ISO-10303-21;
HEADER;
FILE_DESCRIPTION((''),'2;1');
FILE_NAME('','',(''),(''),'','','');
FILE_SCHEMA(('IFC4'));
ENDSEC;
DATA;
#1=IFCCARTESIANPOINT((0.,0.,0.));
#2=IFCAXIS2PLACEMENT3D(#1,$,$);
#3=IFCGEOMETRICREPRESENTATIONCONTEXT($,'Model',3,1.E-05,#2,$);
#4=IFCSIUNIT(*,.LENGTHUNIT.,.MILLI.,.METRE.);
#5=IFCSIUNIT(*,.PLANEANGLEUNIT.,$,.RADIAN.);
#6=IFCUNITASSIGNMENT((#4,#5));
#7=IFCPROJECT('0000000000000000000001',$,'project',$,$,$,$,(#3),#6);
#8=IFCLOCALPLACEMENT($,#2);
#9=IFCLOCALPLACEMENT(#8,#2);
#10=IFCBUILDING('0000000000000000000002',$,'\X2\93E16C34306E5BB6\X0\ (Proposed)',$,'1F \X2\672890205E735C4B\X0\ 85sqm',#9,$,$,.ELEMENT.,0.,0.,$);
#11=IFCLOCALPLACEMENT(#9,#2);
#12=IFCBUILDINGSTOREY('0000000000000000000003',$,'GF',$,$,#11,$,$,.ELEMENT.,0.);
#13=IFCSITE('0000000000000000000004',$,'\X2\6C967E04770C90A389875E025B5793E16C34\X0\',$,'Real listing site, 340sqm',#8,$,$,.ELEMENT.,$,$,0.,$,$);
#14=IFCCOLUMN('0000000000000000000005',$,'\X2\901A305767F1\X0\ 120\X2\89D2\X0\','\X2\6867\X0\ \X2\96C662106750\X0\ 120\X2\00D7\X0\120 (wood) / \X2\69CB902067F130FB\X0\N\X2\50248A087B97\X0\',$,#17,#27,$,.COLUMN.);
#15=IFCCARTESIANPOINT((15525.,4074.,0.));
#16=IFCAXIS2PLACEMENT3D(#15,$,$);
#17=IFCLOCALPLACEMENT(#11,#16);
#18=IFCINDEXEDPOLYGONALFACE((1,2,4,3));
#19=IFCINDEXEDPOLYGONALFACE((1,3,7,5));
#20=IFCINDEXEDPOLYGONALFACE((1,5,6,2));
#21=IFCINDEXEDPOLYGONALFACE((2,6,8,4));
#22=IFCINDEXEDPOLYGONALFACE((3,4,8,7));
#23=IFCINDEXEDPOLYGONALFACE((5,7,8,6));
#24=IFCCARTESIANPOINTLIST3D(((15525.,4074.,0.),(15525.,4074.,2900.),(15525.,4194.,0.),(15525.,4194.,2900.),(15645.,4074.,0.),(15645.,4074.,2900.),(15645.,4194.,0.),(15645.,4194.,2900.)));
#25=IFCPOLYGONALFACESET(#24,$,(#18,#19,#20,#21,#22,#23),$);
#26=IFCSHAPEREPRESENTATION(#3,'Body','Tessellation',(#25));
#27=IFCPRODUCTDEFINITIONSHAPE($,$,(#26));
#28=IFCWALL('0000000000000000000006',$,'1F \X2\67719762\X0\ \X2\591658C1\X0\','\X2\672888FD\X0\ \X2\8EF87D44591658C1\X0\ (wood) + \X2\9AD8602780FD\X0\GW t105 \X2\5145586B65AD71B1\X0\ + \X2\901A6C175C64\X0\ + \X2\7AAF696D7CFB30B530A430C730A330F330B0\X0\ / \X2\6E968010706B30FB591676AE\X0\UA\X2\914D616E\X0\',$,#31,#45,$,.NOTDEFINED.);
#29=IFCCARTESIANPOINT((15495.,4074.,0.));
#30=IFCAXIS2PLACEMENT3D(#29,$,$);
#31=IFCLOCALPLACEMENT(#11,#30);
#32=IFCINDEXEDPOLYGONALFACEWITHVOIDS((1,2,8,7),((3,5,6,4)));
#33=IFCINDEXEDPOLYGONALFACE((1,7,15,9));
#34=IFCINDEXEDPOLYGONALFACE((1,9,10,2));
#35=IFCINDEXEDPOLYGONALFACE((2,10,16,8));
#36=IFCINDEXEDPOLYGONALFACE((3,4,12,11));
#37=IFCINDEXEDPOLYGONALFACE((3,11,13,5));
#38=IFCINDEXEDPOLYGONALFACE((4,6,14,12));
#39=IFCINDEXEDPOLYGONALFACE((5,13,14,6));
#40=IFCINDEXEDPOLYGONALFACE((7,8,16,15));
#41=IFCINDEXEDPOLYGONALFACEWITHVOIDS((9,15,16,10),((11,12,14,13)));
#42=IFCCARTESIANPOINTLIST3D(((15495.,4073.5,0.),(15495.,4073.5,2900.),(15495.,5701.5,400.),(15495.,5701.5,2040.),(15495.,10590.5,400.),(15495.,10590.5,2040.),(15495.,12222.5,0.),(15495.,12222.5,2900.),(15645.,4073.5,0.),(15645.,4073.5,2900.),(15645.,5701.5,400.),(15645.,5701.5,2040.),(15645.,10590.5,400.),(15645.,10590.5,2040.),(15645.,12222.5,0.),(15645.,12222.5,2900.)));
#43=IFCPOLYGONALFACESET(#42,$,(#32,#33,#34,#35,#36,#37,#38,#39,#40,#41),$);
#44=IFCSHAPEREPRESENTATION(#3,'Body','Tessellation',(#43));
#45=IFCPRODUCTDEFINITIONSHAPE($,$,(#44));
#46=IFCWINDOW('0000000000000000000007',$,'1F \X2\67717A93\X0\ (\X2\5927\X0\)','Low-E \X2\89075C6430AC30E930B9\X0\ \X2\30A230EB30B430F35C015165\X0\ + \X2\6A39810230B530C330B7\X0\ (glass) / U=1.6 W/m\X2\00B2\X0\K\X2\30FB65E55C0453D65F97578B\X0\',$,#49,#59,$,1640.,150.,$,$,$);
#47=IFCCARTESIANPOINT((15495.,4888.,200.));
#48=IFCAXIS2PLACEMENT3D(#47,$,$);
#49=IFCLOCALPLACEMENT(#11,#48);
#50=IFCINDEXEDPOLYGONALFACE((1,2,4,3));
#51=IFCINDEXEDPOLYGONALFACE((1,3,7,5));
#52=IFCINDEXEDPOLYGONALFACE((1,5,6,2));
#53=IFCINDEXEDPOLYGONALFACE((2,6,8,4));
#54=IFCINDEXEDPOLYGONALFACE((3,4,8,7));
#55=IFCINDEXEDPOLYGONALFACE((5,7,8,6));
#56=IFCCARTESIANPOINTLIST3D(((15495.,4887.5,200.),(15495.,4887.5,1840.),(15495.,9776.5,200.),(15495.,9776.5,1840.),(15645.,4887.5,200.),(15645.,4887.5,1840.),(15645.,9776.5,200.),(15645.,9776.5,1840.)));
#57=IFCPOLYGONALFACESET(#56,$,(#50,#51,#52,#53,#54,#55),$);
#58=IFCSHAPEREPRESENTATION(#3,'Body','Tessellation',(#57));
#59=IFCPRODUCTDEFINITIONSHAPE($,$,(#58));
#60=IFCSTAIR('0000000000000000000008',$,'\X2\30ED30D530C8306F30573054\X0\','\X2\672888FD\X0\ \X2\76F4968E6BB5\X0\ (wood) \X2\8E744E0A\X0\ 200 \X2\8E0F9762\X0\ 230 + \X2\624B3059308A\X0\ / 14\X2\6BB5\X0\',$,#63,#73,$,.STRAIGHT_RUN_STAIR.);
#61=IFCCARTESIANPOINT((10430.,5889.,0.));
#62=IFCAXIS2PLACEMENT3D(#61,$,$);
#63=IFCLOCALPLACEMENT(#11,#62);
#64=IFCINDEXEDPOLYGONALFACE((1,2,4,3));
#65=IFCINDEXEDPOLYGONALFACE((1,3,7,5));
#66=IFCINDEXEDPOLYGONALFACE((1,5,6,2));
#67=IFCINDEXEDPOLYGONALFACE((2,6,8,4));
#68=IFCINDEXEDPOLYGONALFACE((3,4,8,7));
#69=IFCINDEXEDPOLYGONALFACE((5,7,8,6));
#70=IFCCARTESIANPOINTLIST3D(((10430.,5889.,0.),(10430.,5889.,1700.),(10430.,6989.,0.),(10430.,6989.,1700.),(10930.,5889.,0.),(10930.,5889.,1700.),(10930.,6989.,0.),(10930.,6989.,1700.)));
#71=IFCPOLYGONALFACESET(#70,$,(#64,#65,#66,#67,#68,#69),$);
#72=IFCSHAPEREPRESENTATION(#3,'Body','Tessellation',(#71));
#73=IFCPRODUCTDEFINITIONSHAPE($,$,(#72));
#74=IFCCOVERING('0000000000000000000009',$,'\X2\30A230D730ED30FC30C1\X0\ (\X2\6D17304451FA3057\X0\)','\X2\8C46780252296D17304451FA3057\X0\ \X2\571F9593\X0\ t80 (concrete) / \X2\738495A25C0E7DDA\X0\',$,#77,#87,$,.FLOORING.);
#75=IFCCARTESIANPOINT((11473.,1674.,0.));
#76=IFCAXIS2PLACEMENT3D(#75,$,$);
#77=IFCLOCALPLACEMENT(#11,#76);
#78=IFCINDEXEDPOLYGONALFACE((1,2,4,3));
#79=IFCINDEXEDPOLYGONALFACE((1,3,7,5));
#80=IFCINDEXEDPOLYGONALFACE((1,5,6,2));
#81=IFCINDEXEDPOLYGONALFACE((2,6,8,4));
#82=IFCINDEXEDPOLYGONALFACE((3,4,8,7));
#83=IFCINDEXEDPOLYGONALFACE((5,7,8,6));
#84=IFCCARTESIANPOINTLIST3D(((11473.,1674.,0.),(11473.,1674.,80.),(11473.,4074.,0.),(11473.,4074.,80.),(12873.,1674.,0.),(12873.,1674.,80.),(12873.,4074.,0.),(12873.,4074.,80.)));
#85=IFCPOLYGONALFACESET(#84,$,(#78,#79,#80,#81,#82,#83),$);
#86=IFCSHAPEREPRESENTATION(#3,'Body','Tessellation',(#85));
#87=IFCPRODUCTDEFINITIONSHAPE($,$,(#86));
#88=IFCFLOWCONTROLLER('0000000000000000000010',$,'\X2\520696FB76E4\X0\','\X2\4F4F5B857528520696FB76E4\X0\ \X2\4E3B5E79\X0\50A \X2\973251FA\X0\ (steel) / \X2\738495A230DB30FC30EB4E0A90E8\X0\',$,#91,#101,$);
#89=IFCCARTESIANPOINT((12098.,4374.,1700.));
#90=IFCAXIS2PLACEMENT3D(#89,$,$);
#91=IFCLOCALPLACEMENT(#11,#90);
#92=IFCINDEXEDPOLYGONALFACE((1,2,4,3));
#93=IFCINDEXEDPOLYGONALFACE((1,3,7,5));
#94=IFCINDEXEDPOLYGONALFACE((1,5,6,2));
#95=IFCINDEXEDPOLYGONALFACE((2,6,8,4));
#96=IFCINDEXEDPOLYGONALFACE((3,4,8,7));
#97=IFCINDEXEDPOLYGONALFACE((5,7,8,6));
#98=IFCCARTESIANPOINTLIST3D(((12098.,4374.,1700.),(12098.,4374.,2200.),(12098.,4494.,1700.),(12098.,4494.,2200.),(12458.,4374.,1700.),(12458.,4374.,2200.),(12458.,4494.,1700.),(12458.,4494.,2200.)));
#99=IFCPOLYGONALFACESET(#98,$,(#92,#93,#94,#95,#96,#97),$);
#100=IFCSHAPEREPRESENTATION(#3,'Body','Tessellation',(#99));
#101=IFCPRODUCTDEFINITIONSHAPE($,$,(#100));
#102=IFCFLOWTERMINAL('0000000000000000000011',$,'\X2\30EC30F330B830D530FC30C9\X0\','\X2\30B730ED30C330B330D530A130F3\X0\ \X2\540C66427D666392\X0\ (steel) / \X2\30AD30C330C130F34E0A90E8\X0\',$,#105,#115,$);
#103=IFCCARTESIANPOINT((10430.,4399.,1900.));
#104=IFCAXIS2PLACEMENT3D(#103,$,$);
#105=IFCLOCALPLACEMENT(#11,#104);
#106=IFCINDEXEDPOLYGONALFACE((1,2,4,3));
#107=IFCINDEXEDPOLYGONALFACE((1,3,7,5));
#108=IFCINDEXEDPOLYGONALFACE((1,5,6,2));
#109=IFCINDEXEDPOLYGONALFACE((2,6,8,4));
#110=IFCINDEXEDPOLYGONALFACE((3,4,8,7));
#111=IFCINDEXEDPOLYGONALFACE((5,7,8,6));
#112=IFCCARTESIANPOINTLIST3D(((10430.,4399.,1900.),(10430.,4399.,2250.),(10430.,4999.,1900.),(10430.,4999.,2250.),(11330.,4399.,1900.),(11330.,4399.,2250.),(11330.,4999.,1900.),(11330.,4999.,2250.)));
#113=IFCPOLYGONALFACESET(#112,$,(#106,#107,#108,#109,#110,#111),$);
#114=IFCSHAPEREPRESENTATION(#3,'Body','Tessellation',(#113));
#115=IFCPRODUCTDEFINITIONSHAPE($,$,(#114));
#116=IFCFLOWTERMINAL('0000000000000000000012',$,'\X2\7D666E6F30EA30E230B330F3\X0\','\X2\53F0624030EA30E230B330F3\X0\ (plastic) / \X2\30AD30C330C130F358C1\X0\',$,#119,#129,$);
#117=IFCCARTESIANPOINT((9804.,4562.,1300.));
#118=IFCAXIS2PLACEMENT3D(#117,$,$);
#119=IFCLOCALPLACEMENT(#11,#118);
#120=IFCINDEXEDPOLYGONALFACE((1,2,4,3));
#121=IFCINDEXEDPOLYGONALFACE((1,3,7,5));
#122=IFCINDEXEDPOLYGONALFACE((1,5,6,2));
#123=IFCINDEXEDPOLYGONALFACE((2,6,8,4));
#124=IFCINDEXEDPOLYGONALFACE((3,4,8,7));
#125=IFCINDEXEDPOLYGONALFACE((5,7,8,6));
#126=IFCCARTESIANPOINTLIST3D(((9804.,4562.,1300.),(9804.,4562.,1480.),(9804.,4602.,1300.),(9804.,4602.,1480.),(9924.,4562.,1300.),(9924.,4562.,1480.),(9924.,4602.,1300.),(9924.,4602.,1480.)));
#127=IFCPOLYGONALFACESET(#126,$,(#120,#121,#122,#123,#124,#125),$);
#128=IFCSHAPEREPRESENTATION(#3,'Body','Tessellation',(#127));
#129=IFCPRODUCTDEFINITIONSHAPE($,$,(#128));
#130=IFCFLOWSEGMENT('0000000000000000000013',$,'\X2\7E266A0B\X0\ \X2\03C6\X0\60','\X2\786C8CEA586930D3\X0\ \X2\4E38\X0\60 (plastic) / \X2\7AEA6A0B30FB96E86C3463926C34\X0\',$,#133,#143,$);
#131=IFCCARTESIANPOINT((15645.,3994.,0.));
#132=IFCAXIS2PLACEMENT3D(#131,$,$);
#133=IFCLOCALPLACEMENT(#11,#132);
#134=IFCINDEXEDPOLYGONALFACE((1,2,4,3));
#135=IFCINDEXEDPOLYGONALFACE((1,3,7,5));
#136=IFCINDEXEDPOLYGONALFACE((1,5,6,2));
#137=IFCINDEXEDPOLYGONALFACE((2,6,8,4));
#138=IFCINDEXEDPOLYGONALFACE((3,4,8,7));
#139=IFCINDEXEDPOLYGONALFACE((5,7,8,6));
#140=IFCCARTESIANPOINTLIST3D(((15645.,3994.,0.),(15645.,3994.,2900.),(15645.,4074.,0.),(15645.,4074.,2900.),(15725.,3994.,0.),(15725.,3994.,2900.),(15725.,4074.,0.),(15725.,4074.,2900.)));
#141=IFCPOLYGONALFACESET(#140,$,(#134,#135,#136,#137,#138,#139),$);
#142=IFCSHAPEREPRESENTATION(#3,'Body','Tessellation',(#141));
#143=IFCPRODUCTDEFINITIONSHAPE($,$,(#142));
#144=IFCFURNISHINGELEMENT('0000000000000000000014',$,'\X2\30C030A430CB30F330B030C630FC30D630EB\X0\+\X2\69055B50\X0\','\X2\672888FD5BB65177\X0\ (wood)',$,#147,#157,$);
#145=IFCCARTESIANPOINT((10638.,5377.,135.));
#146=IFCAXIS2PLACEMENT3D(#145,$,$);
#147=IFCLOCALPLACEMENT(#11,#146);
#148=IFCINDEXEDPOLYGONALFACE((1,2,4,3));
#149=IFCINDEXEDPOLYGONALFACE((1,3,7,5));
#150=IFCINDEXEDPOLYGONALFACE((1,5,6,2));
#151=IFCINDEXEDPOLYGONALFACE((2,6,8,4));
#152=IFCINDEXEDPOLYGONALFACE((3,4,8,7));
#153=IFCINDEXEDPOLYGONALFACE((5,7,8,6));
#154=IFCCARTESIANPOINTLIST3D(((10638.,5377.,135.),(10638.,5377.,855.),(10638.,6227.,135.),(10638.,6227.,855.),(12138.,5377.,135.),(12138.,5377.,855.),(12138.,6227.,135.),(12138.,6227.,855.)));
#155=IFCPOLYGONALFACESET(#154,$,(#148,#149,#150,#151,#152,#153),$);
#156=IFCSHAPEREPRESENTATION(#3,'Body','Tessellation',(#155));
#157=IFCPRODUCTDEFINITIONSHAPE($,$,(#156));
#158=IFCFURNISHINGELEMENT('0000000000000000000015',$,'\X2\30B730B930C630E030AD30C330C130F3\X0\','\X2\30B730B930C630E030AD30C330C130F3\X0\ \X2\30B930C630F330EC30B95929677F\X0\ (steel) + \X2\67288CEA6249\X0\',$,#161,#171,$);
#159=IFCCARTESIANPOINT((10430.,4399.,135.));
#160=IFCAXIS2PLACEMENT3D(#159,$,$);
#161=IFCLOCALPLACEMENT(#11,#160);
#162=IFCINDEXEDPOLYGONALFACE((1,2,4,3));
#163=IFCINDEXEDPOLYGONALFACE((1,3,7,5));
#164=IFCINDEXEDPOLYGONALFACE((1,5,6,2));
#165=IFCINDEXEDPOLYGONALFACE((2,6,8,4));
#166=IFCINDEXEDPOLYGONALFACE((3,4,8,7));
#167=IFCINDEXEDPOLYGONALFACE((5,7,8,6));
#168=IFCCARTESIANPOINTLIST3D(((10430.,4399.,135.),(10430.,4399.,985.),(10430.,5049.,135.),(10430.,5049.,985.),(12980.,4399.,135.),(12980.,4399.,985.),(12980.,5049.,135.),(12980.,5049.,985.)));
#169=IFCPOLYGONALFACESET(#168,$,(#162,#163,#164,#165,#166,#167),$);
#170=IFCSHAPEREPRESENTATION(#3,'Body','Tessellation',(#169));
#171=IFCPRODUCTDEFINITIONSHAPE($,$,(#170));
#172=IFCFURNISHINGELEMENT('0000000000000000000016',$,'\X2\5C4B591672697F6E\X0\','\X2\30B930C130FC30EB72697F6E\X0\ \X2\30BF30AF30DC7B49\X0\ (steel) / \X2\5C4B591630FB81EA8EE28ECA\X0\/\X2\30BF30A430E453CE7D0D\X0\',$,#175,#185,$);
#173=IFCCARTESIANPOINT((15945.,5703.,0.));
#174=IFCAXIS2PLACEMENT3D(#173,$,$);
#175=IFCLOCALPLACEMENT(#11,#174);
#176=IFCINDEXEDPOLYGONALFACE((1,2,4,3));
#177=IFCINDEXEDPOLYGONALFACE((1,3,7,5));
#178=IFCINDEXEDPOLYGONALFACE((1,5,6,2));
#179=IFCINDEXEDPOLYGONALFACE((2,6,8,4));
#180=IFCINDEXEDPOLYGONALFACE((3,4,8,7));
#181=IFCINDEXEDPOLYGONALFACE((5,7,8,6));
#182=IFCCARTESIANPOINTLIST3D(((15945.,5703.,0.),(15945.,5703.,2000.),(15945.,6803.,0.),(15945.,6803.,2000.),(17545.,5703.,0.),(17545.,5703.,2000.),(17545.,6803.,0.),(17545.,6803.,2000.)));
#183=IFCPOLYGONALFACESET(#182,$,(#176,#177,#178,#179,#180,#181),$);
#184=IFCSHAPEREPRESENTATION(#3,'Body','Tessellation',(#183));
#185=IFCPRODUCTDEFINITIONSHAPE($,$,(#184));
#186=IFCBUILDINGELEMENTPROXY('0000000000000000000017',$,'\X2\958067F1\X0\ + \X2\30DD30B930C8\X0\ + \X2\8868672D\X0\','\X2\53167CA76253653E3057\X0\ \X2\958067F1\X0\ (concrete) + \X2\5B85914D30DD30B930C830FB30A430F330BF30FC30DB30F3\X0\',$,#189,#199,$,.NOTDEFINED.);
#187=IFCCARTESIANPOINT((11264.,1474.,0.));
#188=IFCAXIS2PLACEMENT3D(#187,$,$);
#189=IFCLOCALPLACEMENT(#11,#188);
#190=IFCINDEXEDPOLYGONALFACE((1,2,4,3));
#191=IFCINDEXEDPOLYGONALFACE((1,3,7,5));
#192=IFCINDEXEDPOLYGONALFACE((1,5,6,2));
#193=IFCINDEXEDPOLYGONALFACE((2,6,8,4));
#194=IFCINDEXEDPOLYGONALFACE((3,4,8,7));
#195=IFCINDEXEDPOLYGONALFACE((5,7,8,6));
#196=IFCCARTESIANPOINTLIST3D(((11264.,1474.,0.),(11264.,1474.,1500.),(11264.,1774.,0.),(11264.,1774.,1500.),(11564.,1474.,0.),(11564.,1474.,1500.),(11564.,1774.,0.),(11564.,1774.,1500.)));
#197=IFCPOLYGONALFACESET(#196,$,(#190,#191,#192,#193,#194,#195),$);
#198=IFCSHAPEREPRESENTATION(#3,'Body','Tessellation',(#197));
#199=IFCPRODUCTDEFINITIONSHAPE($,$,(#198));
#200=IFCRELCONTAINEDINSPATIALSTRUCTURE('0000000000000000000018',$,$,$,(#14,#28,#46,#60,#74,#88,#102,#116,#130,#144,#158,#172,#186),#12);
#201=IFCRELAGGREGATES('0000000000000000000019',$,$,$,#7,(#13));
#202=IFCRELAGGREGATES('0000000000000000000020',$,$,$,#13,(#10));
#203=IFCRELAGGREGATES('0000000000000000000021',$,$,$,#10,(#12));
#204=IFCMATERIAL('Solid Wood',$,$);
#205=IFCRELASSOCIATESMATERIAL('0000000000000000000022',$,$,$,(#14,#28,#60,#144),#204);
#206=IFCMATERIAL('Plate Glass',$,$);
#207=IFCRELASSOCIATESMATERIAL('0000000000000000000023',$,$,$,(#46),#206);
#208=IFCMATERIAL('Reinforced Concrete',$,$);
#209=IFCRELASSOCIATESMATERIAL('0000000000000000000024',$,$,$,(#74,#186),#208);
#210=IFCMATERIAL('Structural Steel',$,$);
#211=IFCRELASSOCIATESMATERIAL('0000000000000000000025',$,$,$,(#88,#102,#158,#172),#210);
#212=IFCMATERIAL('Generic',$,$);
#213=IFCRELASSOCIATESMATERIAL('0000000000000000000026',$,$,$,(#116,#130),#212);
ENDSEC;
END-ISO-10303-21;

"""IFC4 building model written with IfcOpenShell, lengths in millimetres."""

from ifc_helpers import new_model, si_unit, frame, frame_2d, origin, place, context, project, spatial, rectangle, extrude, material, element, fill, save


model = new_model("IFC4")

# Units and contexts
model_context = context("Model", 3, precision=1e-05, world=origin())
ifc_project = project(units=[si_unit("LENGTHUNIT", "METRE", prefix="MILLI"), si_unit("PLANEANGLEUNIT", "RADIAN")], contexts=[model_context])

# Site, building, storey
site_placement = place(None, origin())
site = spatial("IfcSite", under=ifc_project, at=site_placement, Name="沖縄県那覇市字鏡水", ObjectType="Real listing site, 340sqm", CompositionType="ELEMENT", RefElevation=0.0)
building_placement = place(site_placement, origin())
building = spatial("IfcBuilding", under=site, at=building_placement, Name="鏡水の家 (Proposed)", ObjectType="1F 木造平屋 85sqm", CompositionType="ELEMENT", ElevationOfRefHeight=0.0, ElevationOfTerrain=0.0)
storey_placement = place(building_placement, origin())
storey = spatial("IfcBuildingStorey", under=building, at=storey_placement, Name="GF", CompositionType="ELEMENT", Elevation=0.0)

# Column
ifc_material_1 = material(Name="Solid Wood")
column_1_placement = place(storey_placement, frame((15525.0, 4074.0, 0.0)))
element("IfcColumn", 1, at=column_1_placement, inside=storey, material=ifc_material_1, Name="通し柱 120角", Description="桧 集成材 120×120 (wood) / 構造柱・N値計算", PredefinedType="COLUMN", context=model_context, shape_type="SweptSolid", body=[
    extrude(rectangle(XDim=120.0, YDim=120.0, at=frame_2d((60.0, 60.0))), frame((15525.0, 4074.0, 0.0)), (0.0, 0.0, 1.0), 2900.0),
])

# Wall, opening, window
wall_1_placement = place(storey_placement, frame((15495.0, 4074.0, 0.0)))
wall_1 = element("IfcWall", 2, at=wall_1_placement, inside=storey, material=ifc_material_1, Name="1F 東面 外壁", Description="木製 軸組外壁 (wood) + 高性能GW t105 充填断熱 + 通気層 + 窯業系サイディング / 準耐火・外皮UA配慮", PredefinedType="NOTDEFINED", context=model_context, shape_type="SweptSolid", body=[
    extrude(rectangle(XDim=150.0, YDim=8149.0, at=frame_2d((75.0, 4074.0))), frame((15495.0, 4074.0, 0.0)), (0.0, 0.0, 1.0), 2900.0),
])
opening_placement = place(storey_placement, frame((15495.0, 4888.0, 200.0)))
opening = element("IfcOpeningElement", 3, at=opening_placement, cuts=wall_1, PredefinedType="NOTDEFINED", context=model_context, shape_type="SweptSolid", body=[
    extrude(rectangle(XDim=150.0, YDim=4889.0, at=frame_2d((75.0, 2444.0))), frame((15495.0, 4888.0, 200.0)), (0.0, 0.0, 1.0), 1640.0),
])
ifc_material_2 = material(Name="Plate Glass")
window_placement = place(storey_placement, frame((15495.0, 4888.0, 200.0)))
window = element("IfcWindow", 4, at=window_placement, inside=storey, material=ifc_material_2, Name="1F 東窓 (大)", Description="Low-E 複層ガラス アルゴン封入 + 樹脂サッシ (glass) / U=1.6 W/m²K・日射取得型", OverallHeight=1640.0, OverallWidth=150.0, context=model_context, shape_type="SweptSolid", body=[
    extrude(rectangle(XDim=150.0, YDim=4889.0, at=frame_2d((75.0, 2444.0))), frame((15495.0, 4888.0, 200.0)), (0.0, 0.0, 1.0), 1640.0),
])
fill(opening, window)

# Stair
stair_placement = place(storey_placement, frame((10430.0, 5889.0, 0.0)))
element("IfcStair", 5, at=stair_placement, inside=storey, material=ifc_material_1, Name="ロフトはしご", Description="木製 直階段 (wood) 蹴上 200 踏面 230 + 手すり / 14段", PredefinedType="STRAIGHT_RUN_STAIR", context=model_context, shape_type="SweptSolid", body=[
    extrude(rectangle(XDim=500.0, YDim=1100.0, at=frame_2d((250.0, 550.0))), frame((10430.0, 5889.0, 0.0)), (0.0, 0.0, 1.0), 1700.0),
])

# Covering
ifc_material_3 = material(Name="Reinforced Concrete")
covering_placement = place(storey_placement, frame((11473.0, 1674.0, 0.0)))
element("IfcCovering", 6, at=covering_placement, inside=storey, material=ifc_material_3, Name="アプローチ (洗い出し)", Description="豆砂利洗い出し 土間 t80 (concrete) / 玄関導線", PredefinedType="FLOORING", context=model_context, shape_type="SweptSolid", body=[
    extrude(rectangle(XDim=1400.0, YDim=2400.0, at=frame_2d((700.0, 1200.0))), frame((11473.0, 1674.0, 0.0)), (0.0, 0.0, 1.0), 80.0),
])

# Flow controller
ifc_material_4 = material(Name="Structural Steel")
flow_controller_placement = place(storey_placement, frame((12098.0, 4374.0, 1700.0)))
element("IfcFlowController", 7, at=flow_controller_placement, inside=storey, material=ifc_material_4, Name="分電盤", Description="住宅用分電盤 主幹50A 露出 (steel) / 玄関ホール上部", context=model_context, shape_type="SweptSolid", body=[
    extrude(rectangle(XDim=360.0, YDim=120.0, at=frame_2d((180.0, 60.0))), frame((12098.0, 4374.0, 1700.0)), (0.0, 0.0, 1.0), 500.0),
])

# Flow terminals
flow_terminal_1_placement = place(storey_placement, frame((10430.0, 4399.0, 1900.0)))
element("IfcFlowTerminal", 8, at=flow_terminal_1_placement, inside=storey, material=ifc_material_4, Name="レンジフード", Description="シロッコファン 同時給排 (steel) / キッチン上部", context=model_context, shape_type="SweptSolid", body=[
    extrude(rectangle(XDim=900.0, YDim=600.0, at=frame_2d((450.0, 300.0))), frame((10430.0, 4399.0, 1900.0)), (0.0, 0.0, 1.0), 350.0),
])
ifc_material_5 = material(Name="Generic")
flow_terminal_2_placement = place(storey_placement, frame((9804.0, 4562.0, 1300.0)))
element("IfcFlowTerminal", 9, at=flow_terminal_2_placement, inside=storey, material=ifc_material_5, Name="給湯リモコン", Description="台所リモコン (plastic) / キッチン壁", context=model_context, shape_type="SweptSolid", body=[
    extrude(rectangle(XDim=120.0, YDim=40.0, at=frame_2d((60.0, 20.0))), frame((9804.0, 4562.0, 1300.0)), (0.0, 0.0, 1.0), 180.0),
])

# Flow segment
flow_segment_placement = place(storey_placement, frame((15645.0, 3994.0, 0.0)))
element("IfcFlowSegment", 10, at=flow_segment_placement, inside=storey, material=ifc_material_5, Name="縦樋 φ60", Description="硬質塩ビ 丸60 (plastic) / 竪樋・雨水排水", context=model_context, shape_type="SweptSolid", body=[
    extrude(rectangle(XDim=80.0, YDim=80.0, at=frame_2d((40.0, 40.0))), frame((15645.0, 3994.0, 0.0)), (0.0, 0.0, 1.0), 2900.0),
])

# Furnishing elements
furnishing_1_placement = place(storey_placement, frame((10638.0, 5377.0, 135.0)))
element("IfcFurnishingElement", 11, at=furnishing_1_placement, inside=storey, material=ifc_material_1, Name="ダイニングテーブル+椅子", Description="木製家具 (wood)", context=model_context, shape_type="SweptSolid", body=[
    extrude(rectangle(XDim=1500.0, YDim=850.0, at=frame_2d((750.0, 425.0))), frame((10638.0, 5377.0, 135.0)), (0.0, 0.0, 1.0), 720.0),
])
furnishing_2_placement = place(storey_placement, frame((10430.0, 4399.0, 135.0)))
element("IfcFurnishingElement", 12, at=furnishing_2_placement, inside=storey, material=ifc_material_4, Name="システムキッチン", Description="システムキッチン ステンレス天板 (steel) + 木質扉", context=model_context, shape_type="SweptSolid", body=[
    extrude(rectangle(XDim=2550.0, YDim=650.0, at=frame_2d((1275.0, 325.0))), frame((10430.0, 4399.0, 135.0)), (0.0, 0.0, 1.0), 850.0),
])
furnishing_3_placement = place(storey_placement, frame((15945.0, 5703.0, 0.0)))
element("IfcFurnishingElement", 13, at=furnishing_3_placement, inside=storey, material=ifc_material_4, Name="屋外物置", Description="スチール物置 タクボ等 (steel) / 屋外・自転車/タイヤ収納", context=model_context, shape_type="SweptSolid", body=[
    extrude(rectangle(XDim=1600.0, YDim=1100.0, at=frame_2d((800.0, 550.0))), frame((15945.0, 5703.0, 0.0)), (0.0, 0.0, 1.0), 2000.0),
])

# Building element proxy
proxy_placement = place(storey_placement, frame((11264.0, 1474.0, 0.0)))
element("IfcBuildingElementProxy", 14, at=proxy_placement, inside=storey, material=ifc_material_3, Name="門柱 + ポスト + 表札", Description="化粧打放し 門柱 (concrete) + 宅配ポスト・インターホン", PredefinedType="NOTDEFINED", context=model_context, shape_type="SweptSolid", body=[
    extrude(rectangle(XDim=300.0, YDim=300.0, at=frame_2d((150.0, 150.0))), frame((11264.0, 1474.0, 0.0)), (0.0, 0.0, 1.0), 1500.0),
])

save(model, "model.ifc")
